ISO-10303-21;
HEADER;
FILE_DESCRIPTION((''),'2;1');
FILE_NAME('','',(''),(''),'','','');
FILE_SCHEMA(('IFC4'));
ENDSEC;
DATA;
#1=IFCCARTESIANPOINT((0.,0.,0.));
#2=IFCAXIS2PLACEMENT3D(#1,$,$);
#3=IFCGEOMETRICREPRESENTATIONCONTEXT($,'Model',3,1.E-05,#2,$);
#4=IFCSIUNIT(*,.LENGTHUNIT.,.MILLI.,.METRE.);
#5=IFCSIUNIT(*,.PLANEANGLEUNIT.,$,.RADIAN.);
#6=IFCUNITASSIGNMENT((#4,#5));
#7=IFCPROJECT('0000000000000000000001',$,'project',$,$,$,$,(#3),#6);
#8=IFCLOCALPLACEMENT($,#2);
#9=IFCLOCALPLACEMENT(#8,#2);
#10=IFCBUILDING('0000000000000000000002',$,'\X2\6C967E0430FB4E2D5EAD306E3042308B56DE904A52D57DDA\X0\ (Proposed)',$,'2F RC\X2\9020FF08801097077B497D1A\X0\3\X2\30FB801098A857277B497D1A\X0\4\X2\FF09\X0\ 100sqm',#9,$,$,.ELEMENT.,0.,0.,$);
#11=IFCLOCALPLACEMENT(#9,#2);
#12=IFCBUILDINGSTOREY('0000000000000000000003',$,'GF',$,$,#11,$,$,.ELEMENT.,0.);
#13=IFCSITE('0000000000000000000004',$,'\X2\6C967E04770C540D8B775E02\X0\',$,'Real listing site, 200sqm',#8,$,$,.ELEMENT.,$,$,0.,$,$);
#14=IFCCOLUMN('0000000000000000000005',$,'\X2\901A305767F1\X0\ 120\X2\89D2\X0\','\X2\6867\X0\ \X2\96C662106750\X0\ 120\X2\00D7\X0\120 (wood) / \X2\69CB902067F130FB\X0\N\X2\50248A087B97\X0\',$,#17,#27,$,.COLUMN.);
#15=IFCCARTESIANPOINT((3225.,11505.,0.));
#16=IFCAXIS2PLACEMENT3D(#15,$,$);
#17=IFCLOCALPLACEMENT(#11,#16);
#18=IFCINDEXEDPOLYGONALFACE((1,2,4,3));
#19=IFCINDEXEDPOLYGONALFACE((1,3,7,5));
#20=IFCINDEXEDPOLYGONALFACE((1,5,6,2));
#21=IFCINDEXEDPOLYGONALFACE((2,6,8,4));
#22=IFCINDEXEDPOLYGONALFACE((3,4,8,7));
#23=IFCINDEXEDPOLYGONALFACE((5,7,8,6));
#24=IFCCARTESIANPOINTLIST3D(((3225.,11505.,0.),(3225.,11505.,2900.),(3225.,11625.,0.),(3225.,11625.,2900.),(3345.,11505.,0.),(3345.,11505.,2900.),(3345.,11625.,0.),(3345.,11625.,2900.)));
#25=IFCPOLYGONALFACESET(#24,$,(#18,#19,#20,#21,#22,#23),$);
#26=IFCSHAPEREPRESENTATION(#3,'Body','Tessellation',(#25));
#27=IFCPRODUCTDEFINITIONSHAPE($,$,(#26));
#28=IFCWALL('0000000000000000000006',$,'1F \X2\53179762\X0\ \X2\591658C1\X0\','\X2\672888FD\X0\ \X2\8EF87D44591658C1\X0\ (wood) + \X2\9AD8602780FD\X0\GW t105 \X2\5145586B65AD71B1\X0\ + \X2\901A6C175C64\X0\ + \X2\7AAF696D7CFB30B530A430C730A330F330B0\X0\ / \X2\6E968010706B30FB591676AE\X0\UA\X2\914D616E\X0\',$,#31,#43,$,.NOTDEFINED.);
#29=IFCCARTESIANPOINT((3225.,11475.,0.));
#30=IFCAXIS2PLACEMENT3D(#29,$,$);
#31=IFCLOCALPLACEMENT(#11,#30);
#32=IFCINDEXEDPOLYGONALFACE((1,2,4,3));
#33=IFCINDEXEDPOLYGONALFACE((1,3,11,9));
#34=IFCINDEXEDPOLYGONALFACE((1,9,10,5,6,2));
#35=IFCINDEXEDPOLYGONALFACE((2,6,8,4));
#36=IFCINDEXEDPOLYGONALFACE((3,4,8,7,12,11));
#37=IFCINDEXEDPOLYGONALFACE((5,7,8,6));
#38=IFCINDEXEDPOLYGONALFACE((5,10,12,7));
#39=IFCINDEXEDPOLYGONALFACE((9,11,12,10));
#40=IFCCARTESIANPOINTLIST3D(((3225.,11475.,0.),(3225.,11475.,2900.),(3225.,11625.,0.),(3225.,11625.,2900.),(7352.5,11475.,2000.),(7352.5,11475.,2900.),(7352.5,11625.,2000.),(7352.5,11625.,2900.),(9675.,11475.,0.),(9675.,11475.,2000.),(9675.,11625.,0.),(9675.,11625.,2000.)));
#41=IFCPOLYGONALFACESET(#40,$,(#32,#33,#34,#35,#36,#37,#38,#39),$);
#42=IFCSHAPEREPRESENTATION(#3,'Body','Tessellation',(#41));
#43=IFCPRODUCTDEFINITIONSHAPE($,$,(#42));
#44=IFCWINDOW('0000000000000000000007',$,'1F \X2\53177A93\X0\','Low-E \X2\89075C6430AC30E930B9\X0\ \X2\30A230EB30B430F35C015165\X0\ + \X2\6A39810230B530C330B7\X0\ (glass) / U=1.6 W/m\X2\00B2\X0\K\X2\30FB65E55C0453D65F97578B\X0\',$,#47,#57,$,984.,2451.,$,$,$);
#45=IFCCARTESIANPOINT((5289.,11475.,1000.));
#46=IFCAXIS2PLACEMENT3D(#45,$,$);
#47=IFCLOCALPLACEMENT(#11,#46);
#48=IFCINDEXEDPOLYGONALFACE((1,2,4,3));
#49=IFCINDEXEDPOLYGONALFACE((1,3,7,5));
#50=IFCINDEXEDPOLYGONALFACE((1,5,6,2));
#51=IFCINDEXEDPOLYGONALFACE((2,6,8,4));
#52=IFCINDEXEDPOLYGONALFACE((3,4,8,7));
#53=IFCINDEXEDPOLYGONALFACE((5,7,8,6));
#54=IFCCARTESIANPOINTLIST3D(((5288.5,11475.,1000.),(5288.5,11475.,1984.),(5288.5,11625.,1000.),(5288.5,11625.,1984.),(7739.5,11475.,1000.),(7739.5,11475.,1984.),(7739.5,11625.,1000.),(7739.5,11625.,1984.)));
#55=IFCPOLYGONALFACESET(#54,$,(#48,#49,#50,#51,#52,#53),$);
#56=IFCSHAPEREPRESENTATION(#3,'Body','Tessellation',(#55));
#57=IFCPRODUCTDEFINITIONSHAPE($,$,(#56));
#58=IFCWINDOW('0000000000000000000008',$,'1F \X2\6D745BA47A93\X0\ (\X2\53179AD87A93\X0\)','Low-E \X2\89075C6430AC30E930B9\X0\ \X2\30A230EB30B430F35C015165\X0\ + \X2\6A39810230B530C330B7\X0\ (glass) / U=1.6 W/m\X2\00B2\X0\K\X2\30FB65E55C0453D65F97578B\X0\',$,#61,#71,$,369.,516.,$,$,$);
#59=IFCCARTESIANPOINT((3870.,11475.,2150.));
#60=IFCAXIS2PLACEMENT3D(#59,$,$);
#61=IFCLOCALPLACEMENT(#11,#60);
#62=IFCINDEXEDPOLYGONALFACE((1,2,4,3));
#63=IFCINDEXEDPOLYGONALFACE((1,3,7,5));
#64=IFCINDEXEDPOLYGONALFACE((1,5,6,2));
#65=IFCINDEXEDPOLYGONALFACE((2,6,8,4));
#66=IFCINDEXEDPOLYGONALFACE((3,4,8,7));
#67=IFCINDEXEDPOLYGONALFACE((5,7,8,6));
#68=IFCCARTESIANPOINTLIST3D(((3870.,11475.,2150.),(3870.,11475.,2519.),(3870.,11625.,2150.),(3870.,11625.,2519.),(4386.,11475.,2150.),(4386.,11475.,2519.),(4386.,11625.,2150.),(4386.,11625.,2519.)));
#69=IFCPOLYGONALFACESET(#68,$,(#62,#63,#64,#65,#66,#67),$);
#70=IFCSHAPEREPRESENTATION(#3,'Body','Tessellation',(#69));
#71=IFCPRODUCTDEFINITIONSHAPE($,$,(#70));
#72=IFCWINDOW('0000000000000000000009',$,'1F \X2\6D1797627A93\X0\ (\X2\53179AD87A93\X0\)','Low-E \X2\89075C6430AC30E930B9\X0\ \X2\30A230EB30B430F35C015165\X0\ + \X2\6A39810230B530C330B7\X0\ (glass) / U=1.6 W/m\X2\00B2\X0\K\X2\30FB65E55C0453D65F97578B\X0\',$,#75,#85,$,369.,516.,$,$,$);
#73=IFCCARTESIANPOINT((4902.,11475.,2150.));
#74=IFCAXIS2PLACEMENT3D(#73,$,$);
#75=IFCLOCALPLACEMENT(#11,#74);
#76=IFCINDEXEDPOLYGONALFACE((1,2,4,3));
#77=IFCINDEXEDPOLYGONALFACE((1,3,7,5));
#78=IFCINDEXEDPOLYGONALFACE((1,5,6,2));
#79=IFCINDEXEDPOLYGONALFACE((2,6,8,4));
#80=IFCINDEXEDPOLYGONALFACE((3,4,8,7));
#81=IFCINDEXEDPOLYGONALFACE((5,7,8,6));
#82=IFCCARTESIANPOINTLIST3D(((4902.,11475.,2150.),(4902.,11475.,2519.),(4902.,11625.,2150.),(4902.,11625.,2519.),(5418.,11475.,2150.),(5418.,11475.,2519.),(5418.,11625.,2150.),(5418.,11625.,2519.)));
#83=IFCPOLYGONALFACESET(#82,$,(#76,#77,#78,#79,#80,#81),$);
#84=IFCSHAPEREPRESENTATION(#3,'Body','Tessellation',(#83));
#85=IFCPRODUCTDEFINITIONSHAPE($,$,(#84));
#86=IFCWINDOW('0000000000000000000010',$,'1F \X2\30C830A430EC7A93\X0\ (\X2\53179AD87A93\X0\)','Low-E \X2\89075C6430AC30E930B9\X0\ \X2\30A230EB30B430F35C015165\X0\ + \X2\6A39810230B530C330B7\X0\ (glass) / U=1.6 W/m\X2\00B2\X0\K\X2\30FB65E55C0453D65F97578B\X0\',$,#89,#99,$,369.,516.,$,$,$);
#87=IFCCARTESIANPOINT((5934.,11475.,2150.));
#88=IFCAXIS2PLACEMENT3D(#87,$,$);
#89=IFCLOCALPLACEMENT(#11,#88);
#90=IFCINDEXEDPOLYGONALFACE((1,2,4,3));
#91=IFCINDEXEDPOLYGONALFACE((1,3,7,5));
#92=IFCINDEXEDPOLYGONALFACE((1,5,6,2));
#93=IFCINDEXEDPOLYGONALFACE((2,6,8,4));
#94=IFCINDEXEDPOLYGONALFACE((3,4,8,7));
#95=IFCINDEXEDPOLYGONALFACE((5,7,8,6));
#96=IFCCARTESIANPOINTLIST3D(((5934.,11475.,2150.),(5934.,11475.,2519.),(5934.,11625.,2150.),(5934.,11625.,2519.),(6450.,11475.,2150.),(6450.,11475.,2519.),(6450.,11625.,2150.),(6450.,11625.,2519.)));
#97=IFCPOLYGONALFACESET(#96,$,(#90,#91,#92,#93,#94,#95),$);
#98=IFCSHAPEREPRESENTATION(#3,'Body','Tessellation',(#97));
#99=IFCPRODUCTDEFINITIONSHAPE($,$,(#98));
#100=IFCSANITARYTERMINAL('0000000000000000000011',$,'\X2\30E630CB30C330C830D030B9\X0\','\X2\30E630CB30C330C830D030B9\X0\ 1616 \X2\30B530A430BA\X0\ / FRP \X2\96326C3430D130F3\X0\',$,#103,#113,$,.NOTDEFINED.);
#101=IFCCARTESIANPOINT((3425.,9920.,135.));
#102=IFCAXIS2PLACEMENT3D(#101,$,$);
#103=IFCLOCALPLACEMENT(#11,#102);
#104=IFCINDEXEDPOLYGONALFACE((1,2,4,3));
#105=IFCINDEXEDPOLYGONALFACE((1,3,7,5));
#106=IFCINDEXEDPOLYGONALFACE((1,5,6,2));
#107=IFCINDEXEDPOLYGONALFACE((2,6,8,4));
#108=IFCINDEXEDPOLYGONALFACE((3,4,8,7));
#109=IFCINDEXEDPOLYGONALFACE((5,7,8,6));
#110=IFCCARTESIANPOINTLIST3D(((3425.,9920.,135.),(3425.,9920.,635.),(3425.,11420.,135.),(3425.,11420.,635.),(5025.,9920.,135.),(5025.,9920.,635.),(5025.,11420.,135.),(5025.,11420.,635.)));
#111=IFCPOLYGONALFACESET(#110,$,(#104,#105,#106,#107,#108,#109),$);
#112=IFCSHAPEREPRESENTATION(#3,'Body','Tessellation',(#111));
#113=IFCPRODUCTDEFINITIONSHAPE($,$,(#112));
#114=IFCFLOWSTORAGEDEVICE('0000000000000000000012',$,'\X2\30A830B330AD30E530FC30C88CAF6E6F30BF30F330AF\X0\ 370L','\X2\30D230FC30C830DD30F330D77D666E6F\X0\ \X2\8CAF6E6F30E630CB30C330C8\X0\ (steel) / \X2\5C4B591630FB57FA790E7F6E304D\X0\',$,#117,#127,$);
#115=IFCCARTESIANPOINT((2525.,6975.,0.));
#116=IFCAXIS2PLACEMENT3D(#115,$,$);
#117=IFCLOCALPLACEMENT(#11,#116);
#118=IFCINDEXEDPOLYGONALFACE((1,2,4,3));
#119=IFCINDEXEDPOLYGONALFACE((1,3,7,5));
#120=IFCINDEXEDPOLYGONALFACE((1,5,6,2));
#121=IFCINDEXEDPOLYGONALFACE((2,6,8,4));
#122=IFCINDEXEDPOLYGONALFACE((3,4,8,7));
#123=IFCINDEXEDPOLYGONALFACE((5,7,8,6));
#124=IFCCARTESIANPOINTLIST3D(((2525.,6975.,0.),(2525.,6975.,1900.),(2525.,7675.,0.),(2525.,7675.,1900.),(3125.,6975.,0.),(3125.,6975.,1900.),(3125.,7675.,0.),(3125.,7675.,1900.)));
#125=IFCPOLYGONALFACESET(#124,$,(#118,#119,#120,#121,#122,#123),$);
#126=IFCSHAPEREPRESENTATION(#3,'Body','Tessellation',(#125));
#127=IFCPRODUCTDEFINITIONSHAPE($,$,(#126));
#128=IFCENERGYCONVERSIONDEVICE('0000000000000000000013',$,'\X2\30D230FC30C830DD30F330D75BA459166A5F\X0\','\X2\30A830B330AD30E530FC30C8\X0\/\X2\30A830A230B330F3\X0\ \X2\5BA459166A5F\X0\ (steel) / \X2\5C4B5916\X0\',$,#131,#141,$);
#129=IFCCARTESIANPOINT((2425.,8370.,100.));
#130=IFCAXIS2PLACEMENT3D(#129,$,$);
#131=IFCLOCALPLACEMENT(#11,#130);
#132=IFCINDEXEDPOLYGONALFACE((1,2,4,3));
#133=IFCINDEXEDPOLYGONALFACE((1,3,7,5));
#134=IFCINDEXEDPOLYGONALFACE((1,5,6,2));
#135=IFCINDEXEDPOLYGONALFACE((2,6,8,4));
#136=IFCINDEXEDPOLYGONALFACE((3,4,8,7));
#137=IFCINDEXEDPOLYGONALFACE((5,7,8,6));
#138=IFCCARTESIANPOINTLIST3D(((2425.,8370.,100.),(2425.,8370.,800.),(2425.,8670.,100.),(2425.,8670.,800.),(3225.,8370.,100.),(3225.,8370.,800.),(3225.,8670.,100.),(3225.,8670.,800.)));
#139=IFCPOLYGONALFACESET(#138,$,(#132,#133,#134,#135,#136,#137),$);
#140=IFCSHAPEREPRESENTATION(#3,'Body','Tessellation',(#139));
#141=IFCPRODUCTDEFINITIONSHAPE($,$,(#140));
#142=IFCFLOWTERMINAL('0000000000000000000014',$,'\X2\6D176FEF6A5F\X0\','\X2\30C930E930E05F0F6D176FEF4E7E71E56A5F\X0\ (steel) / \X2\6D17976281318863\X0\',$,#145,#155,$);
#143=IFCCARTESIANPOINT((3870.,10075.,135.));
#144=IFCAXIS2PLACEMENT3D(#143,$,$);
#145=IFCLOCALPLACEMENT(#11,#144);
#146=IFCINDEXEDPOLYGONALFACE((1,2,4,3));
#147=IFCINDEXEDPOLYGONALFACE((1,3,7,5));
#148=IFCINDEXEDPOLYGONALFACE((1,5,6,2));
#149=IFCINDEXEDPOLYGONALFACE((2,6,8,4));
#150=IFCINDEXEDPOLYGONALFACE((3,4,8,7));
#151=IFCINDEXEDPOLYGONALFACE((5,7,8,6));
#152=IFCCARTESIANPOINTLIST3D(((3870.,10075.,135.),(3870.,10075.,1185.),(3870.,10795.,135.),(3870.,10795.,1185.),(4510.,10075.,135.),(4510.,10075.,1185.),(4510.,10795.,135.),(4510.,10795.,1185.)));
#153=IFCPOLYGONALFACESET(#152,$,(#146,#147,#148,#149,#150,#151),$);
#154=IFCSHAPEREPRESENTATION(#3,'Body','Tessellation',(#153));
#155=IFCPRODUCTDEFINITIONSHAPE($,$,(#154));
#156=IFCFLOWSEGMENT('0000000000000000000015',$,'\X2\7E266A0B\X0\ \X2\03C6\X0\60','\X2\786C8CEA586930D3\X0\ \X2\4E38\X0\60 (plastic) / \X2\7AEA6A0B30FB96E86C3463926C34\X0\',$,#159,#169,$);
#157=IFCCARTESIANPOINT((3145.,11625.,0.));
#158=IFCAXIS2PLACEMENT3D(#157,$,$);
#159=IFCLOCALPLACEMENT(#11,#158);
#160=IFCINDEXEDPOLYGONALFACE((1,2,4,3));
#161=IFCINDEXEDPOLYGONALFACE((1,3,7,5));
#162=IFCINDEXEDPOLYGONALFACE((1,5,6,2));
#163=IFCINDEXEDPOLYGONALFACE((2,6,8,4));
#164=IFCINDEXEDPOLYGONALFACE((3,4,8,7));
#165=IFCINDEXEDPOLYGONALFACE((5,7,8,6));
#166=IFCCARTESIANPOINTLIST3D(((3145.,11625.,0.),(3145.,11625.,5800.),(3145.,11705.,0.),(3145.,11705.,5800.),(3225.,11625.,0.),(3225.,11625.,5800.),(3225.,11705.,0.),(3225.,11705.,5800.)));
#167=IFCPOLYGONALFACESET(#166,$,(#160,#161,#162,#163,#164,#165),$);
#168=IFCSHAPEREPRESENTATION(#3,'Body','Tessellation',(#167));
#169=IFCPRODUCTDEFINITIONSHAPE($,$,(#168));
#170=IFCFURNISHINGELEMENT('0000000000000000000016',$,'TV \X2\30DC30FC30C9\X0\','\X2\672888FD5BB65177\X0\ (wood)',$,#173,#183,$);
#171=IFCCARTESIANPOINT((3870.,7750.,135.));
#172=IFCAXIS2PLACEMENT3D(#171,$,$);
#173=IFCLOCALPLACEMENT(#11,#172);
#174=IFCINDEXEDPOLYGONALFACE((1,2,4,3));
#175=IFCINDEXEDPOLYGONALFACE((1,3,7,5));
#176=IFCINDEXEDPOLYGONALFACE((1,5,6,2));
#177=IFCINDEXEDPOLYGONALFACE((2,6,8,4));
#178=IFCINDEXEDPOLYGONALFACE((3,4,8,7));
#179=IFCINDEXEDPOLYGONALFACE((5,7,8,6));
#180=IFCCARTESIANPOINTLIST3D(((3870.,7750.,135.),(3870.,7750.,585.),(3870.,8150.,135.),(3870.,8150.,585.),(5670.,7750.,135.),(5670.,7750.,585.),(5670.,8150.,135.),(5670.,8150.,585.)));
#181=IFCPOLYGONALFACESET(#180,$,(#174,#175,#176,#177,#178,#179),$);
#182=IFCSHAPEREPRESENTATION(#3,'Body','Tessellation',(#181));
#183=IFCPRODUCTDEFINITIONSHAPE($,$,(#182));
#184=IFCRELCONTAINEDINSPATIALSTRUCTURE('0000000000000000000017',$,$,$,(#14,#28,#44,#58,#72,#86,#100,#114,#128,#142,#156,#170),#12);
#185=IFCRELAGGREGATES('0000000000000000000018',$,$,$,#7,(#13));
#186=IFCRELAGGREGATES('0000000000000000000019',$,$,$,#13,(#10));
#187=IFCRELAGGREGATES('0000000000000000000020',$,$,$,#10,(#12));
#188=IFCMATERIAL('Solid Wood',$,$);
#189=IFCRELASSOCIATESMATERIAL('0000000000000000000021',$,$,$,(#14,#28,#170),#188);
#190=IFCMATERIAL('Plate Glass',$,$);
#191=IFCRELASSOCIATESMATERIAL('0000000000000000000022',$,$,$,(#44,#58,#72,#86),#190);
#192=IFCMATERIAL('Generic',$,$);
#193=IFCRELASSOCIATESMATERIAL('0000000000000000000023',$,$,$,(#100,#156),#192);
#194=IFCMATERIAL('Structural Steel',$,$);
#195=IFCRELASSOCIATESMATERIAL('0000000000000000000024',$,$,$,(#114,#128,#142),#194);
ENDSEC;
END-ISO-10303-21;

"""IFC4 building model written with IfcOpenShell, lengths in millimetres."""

from ifc_helpers import new_model, si_unit, frame, frame_2d, origin, place, context, project, spatial, rectangle, extrude, material, element, fill, save


model = new_model("IFC4")

# Units and contexts
model_context = context("Model", 3, precision=1e-05, world=origin())
ifc_project = project(units=[si_unit("LENGTHUNIT", "METRE", prefix="MILLI"), si_unit("PLANEANGLEUNIT", "RADIAN")], contexts=[model_context])

# Site, building, storey
site_placement = place(None, origin())
site = spatial("IfcSite", under=ifc_project, at=site_placement, Name="沖縄県名護市", ObjectType="Real listing site, 200sqm", CompositionType="ELEMENT", RefElevation=0.0)
building_placement = place(site_placement, origin())
building = spatial("IfcBuilding", under=site, at=building_placement, Name="沖縄・中庭のある回遊動線 (Proposed)", ObjectType="2F RC造（耐震等級3・耐風圧等級4） 100sqm", CompositionType="ELEMENT", ElevationOfRefHeight=0.0, ElevationOfTerrain=0.0)
storey_placement = place(building_placement, origin())
storey = spatial("IfcBuildingStorey", under=building, at=storey_placement, Name="GF", CompositionType="ELEMENT", Elevation=0.0)

# Column
ifc_material_1 = material(Name="Solid Wood")
column_1_placement = place(storey_placement, frame((3225.0, 11505.0, 0.0)))
element("IfcColumn", 1, at=column_1_placement, inside=storey, material=ifc_material_1, Name="通し柱 120角", Description="桧 集成材 120×120 (wood) / 構造柱・N値計算", PredefinedType="COLUMN", context=model_context, shape_type="SweptSolid", body=[
    extrude(rectangle(XDim=120.0, YDim=120.0, at=frame_2d((60.0, 60.0))), frame((3225.0, 11505.0, 0.0)), (0.0, 0.0, 1.0), 2900.0),
])

# Wall, openings, windows
wall_1_placement = place(storey_placement, frame((3225.0, 11475.0, 0.0)))
wall_1 = element("IfcWall", 2, at=wall_1_placement, inside=storey, material=ifc_material_1, Name="1F 北面 外壁", Description="木製 軸組外壁 (wood) + 高性能GW t105 充填断熱 + 通気層 + 窯業系サイディング / 準耐火・外皮UA配慮", PredefinedType="NOTDEFINED", context=model_context, shape_type="SweptSolid", body=[
    extrude(rectangle(XDim=6450.0, YDim=150.0, at=frame_2d((3225.0, 75.0))), frame((3225.0, 11475.0, 0.0)), (0.0, 0.0, 1.0), 2900.0),
])
opening_1_placement = place(storey_placement, frame((5289.0, 11475.0, 1000.0)))
opening_1 = element("IfcOpeningElement", 3, at=opening_1_placement, cuts=wall_1, PredefinedType="NOTDEFINED", context=model_context, shape_type="SweptSolid", body=[
    extrude(rectangle(XDim=2451.0, YDim=150.0, at=frame_2d((1225.0, 75.0))), frame((5289.0, 11475.0, 1000.0)), (0.0, 0.0, 1.0), 984.0),
])
opening_2_placement = place(storey_placement, frame((3870.0, 11475.0, 2150.0)))
opening_2 = element("IfcOpeningElement", 4, at=opening_2_placement, cuts=wall_1, PredefinedType="NOTDEFINED", context=model_context, shape_type="SweptSolid", body=[
    extrude(rectangle(XDim=516.0, YDim=150.0, at=frame_2d((258.0, 75.0))), frame((3870.0, 11475.0, 2150.0)), (0.0, 0.0, 1.0), 369.0),
])
opening_3_placement = place(storey_placement, frame((4902.0, 11475.0, 2150.0)))
opening_3 = element("IfcOpeningElement", 5, at=opening_3_placement, cuts=wall_1, PredefinedType="NOTDEFINED", context=model_context, shape_type="SweptSolid", body=[
    extrude(rectangle(XDim=516.0, YDim=150.0, at=frame_2d((258.0, 75.0))), frame((4902.0, 11475.0, 2150.0)), (0.0, 0.0, 1.0), 369.0),
])
opening_4_placement = place(storey_placement, frame((5934.0, 11475.0, 2150.0)))
opening_4 = element("IfcOpeningElement", 6, at=opening_4_placement, cuts=wall_1, PredefinedType="NOTDEFINED", context=model_context, shape_type="SweptSolid", body=[
    extrude(rectangle(XDim=516.0, YDim=150.0, at=frame_2d((258.0, 75.0))), frame((5934.0, 11475.0, 2150.0)), (0.0, 0.0, 1.0), 369.0),
])
ifc_material_2 = material(Name="Plate Glass")
window_1_placement = place(storey_placement, frame((5289.0, 11475.0, 1000.0)))
window_1 = element("IfcWindow", 7, at=window_1_placement, inside=storey, material=ifc_material_2, Name="1F 北窓", Description="Low-E 複層ガラス アルゴン封入 + 樹脂サッシ (glass) / U=1.6 W/m²K・日射取得型", OverallHeight=984.0, OverallWidth=2451.0, context=model_context, shape_type="SweptSolid", body=[
    extrude(rectangle(XDim=2451.0, YDim=150.0, at=frame_2d((1225.0, 75.0))), frame((5289.0, 11475.0, 1000.0)), (0.0, 0.0, 1.0), 984.0),
])
fill(opening_1, window_1)
window_2_placement = place(storey_placement, frame((3870.0, 11475.0, 2150.0)))
window_2 = element("IfcWindow", 8, at=window_2_placement, inside=storey, material=ifc_material_2, Name="1F 浴室窓 (北高窓)", Description="Low-E 複層ガラス アルゴン封入 + 樹脂サッシ (glass) / U=1.6 W/m²K・日射取得型", OverallHeight=369.0, OverallWidth=516.0, context=model_context, shape_type="SweptSolid", body=[
    extrude(rectangle(XDim=516.0, YDim=150.0, at=frame_2d((258.0, 75.0))), frame((3870.0, 11475.0, 2150.0)), (0.0, 0.0, 1.0), 369.0),
])
fill(opening_2, window_2)
window_3_placement = place(storey_placement, frame((4902.0, 11475.0, 2150.0)))
window_3 = element("IfcWindow", 9, at=window_3_placement, inside=storey, material=ifc_material_2, Name="1F 洗面窓 (北高窓)", Description="Low-E 複層ガラス アルゴン封入 + 樹脂サッシ (glass) / U=1.6 W/m²K・日射取得型", OverallHeight=369.0, OverallWidth=516.0, context=model_context, shape_type="SweptSolid", body=[
    extrude(rectangle(XDim=516.0, YDim=150.0, at=frame_2d((258.0, 75.0))), frame((4902.0, 11475.0, 2150.0)), (0.0, 0.0, 1.0), 369.0),
])
fill(opening_3, window_3)
window_4_placement = place(storey_placement, frame((5934.0, 11475.0, 2150.0)))
window_4 = element("IfcWindow", 10, at=window_4_placement, inside=storey, material=ifc_material_2, Name="1F トイレ窓 (北高窓)", Description="Low-E 複層ガラス アルゴン封入 + 樹脂サッシ (glass) / U=1.6 W/m²K・日射取得型", OverallHeight=369.0, OverallWidth=516.0, context=model_context, shape_type="SweptSolid", body=[
    extrude(rectangle(XDim=516.0, YDim=150.0, at=frame_2d((258.0, 75.0))), frame((5934.0, 11475.0, 2150.0)), (0.0, 0.0, 1.0), 369.0),
])
fill(opening_4, window_4)

# Sanitary terminal
ifc_material_3 = material(Name="Generic")
sanitary_terminal_placement = place(storey_placement, frame((3425.0, 9920.0, 135.0)))
element("IfcSanitaryTerminal", 11, at=sanitary_terminal_placement, inside=storey, material=ifc_material_3, Name="ユニットバス", Description="ユニットバス 1616 サイズ / FRP 防水パン", PredefinedType="NOTDEFINED", context=model_context, shape_type="SweptSolid", body=[
    extrude(rectangle(XDim=1600.0, YDim=1500.0, at=frame_2d((800.0, 750.0))), frame((3425.0, 9920.0, 135.0)), (0.0, 0.0, 1.0), 500.0),
])

# Flow storage device
ifc_material_4 = material(Name="Structural Steel")
flow_storage_device_placement = place(storey_placement, frame((2525.0, 6975.0, 0.0)))
element("IfcFlowStorageDevice", 12, at=flow_storage_device_placement, inside=storey, material=ifc_material_4, Name="エコキュート貯湯タンク 370L", Description="ヒートポンプ給湯 貯湯ユニット (steel) / 屋外・基礎置き", context=model_context, shape_type="SweptSolid", body=[
    extrude(rectangle(XDim=600.0, YDim=700.0, at=frame_2d((300.0, 350.0))), frame((2525.0, 6975.0, 0.0)), (0.0, 0.0, 1.0), 1900.0),
])

# Energy conversion device
energy_conversion_device_placement = place(storey_placement, frame((2425.0, 8370.0, 100.0)))
element("IfcEnergyConversionDevice", 13, at=energy_conversion_device_placement, inside=storey, material=ifc_material_4, Name="ヒートポンプ室外機", Description="エコキュート/エアコン 室外機 (steel) / 屋外", context=model_context, shape_type="SweptSolid", body=[
    extrude(rectangle(XDim=800.0, YDim=300.0, at=frame_2d((400.0, 150.0))), frame((2425.0, 8370.0, 100.0)), (0.0, 0.0, 1.0), 700.0),
])

# Flow terminal
flow_terminal_placement = place(storey_placement, frame((3870.0, 10075.0, 135.0)))
element("IfcFlowTerminal", 14, at=flow_terminal_placement, inside=storey, material=ifc_material_4, Name="洗濯機", Description="ドラム式洗濯乾燥機 (steel) / 洗面脱衣", context=model_context, shape_type="SweptSolid", body=[
    extrude(rectangle(XDim=640.0, YDim=720.0, at=frame_2d((320.0, 360.0))), frame((3870.0, 10075.0, 135.0)), (0.0, 0.0, 1.0), 1050.0),
])

# Flow segment
flow_segment_placement = place(storey_placement, frame((3145.0, 11625.0, 0.0)))
element("IfcFlowSegment", 15, at=flow_segment_placement, inside=storey, material=ifc_material_3, Name="縦樋 φ60", Description="硬質塩ビ 丸60 (plastic) / 竪樋・雨水排水", context=model_context, shape_type="SweptSolid", body=[
    extrude(rectangle(XDim=80.0, YDim=80.0, at=frame_2d((40.0, 40.0))), frame((3145.0, 11625.0, 0.0)), (0.0, 0.0, 1.0), 5800.0),
])

# Furnishing element
furnishing_placement = place(storey_placement, frame((3870.0, 7750.0, 135.0)))
element("IfcFurnishingElement", 16, at=furnishing_placement, inside=storey, material=ifc_material_1, Name="TV ボード", Description="木製家具 (wood)", context=model_context, shape_type="SweptSolid", body=[
    extrude(rectangle(XDim=1800.0, YDim=400.0, at=frame_2d((900.0, 200.0))), frame((3870.0, 7750.0, 135.0)), (0.0, 0.0, 1.0), 450.0),
])

save(model, "model.ifc")
